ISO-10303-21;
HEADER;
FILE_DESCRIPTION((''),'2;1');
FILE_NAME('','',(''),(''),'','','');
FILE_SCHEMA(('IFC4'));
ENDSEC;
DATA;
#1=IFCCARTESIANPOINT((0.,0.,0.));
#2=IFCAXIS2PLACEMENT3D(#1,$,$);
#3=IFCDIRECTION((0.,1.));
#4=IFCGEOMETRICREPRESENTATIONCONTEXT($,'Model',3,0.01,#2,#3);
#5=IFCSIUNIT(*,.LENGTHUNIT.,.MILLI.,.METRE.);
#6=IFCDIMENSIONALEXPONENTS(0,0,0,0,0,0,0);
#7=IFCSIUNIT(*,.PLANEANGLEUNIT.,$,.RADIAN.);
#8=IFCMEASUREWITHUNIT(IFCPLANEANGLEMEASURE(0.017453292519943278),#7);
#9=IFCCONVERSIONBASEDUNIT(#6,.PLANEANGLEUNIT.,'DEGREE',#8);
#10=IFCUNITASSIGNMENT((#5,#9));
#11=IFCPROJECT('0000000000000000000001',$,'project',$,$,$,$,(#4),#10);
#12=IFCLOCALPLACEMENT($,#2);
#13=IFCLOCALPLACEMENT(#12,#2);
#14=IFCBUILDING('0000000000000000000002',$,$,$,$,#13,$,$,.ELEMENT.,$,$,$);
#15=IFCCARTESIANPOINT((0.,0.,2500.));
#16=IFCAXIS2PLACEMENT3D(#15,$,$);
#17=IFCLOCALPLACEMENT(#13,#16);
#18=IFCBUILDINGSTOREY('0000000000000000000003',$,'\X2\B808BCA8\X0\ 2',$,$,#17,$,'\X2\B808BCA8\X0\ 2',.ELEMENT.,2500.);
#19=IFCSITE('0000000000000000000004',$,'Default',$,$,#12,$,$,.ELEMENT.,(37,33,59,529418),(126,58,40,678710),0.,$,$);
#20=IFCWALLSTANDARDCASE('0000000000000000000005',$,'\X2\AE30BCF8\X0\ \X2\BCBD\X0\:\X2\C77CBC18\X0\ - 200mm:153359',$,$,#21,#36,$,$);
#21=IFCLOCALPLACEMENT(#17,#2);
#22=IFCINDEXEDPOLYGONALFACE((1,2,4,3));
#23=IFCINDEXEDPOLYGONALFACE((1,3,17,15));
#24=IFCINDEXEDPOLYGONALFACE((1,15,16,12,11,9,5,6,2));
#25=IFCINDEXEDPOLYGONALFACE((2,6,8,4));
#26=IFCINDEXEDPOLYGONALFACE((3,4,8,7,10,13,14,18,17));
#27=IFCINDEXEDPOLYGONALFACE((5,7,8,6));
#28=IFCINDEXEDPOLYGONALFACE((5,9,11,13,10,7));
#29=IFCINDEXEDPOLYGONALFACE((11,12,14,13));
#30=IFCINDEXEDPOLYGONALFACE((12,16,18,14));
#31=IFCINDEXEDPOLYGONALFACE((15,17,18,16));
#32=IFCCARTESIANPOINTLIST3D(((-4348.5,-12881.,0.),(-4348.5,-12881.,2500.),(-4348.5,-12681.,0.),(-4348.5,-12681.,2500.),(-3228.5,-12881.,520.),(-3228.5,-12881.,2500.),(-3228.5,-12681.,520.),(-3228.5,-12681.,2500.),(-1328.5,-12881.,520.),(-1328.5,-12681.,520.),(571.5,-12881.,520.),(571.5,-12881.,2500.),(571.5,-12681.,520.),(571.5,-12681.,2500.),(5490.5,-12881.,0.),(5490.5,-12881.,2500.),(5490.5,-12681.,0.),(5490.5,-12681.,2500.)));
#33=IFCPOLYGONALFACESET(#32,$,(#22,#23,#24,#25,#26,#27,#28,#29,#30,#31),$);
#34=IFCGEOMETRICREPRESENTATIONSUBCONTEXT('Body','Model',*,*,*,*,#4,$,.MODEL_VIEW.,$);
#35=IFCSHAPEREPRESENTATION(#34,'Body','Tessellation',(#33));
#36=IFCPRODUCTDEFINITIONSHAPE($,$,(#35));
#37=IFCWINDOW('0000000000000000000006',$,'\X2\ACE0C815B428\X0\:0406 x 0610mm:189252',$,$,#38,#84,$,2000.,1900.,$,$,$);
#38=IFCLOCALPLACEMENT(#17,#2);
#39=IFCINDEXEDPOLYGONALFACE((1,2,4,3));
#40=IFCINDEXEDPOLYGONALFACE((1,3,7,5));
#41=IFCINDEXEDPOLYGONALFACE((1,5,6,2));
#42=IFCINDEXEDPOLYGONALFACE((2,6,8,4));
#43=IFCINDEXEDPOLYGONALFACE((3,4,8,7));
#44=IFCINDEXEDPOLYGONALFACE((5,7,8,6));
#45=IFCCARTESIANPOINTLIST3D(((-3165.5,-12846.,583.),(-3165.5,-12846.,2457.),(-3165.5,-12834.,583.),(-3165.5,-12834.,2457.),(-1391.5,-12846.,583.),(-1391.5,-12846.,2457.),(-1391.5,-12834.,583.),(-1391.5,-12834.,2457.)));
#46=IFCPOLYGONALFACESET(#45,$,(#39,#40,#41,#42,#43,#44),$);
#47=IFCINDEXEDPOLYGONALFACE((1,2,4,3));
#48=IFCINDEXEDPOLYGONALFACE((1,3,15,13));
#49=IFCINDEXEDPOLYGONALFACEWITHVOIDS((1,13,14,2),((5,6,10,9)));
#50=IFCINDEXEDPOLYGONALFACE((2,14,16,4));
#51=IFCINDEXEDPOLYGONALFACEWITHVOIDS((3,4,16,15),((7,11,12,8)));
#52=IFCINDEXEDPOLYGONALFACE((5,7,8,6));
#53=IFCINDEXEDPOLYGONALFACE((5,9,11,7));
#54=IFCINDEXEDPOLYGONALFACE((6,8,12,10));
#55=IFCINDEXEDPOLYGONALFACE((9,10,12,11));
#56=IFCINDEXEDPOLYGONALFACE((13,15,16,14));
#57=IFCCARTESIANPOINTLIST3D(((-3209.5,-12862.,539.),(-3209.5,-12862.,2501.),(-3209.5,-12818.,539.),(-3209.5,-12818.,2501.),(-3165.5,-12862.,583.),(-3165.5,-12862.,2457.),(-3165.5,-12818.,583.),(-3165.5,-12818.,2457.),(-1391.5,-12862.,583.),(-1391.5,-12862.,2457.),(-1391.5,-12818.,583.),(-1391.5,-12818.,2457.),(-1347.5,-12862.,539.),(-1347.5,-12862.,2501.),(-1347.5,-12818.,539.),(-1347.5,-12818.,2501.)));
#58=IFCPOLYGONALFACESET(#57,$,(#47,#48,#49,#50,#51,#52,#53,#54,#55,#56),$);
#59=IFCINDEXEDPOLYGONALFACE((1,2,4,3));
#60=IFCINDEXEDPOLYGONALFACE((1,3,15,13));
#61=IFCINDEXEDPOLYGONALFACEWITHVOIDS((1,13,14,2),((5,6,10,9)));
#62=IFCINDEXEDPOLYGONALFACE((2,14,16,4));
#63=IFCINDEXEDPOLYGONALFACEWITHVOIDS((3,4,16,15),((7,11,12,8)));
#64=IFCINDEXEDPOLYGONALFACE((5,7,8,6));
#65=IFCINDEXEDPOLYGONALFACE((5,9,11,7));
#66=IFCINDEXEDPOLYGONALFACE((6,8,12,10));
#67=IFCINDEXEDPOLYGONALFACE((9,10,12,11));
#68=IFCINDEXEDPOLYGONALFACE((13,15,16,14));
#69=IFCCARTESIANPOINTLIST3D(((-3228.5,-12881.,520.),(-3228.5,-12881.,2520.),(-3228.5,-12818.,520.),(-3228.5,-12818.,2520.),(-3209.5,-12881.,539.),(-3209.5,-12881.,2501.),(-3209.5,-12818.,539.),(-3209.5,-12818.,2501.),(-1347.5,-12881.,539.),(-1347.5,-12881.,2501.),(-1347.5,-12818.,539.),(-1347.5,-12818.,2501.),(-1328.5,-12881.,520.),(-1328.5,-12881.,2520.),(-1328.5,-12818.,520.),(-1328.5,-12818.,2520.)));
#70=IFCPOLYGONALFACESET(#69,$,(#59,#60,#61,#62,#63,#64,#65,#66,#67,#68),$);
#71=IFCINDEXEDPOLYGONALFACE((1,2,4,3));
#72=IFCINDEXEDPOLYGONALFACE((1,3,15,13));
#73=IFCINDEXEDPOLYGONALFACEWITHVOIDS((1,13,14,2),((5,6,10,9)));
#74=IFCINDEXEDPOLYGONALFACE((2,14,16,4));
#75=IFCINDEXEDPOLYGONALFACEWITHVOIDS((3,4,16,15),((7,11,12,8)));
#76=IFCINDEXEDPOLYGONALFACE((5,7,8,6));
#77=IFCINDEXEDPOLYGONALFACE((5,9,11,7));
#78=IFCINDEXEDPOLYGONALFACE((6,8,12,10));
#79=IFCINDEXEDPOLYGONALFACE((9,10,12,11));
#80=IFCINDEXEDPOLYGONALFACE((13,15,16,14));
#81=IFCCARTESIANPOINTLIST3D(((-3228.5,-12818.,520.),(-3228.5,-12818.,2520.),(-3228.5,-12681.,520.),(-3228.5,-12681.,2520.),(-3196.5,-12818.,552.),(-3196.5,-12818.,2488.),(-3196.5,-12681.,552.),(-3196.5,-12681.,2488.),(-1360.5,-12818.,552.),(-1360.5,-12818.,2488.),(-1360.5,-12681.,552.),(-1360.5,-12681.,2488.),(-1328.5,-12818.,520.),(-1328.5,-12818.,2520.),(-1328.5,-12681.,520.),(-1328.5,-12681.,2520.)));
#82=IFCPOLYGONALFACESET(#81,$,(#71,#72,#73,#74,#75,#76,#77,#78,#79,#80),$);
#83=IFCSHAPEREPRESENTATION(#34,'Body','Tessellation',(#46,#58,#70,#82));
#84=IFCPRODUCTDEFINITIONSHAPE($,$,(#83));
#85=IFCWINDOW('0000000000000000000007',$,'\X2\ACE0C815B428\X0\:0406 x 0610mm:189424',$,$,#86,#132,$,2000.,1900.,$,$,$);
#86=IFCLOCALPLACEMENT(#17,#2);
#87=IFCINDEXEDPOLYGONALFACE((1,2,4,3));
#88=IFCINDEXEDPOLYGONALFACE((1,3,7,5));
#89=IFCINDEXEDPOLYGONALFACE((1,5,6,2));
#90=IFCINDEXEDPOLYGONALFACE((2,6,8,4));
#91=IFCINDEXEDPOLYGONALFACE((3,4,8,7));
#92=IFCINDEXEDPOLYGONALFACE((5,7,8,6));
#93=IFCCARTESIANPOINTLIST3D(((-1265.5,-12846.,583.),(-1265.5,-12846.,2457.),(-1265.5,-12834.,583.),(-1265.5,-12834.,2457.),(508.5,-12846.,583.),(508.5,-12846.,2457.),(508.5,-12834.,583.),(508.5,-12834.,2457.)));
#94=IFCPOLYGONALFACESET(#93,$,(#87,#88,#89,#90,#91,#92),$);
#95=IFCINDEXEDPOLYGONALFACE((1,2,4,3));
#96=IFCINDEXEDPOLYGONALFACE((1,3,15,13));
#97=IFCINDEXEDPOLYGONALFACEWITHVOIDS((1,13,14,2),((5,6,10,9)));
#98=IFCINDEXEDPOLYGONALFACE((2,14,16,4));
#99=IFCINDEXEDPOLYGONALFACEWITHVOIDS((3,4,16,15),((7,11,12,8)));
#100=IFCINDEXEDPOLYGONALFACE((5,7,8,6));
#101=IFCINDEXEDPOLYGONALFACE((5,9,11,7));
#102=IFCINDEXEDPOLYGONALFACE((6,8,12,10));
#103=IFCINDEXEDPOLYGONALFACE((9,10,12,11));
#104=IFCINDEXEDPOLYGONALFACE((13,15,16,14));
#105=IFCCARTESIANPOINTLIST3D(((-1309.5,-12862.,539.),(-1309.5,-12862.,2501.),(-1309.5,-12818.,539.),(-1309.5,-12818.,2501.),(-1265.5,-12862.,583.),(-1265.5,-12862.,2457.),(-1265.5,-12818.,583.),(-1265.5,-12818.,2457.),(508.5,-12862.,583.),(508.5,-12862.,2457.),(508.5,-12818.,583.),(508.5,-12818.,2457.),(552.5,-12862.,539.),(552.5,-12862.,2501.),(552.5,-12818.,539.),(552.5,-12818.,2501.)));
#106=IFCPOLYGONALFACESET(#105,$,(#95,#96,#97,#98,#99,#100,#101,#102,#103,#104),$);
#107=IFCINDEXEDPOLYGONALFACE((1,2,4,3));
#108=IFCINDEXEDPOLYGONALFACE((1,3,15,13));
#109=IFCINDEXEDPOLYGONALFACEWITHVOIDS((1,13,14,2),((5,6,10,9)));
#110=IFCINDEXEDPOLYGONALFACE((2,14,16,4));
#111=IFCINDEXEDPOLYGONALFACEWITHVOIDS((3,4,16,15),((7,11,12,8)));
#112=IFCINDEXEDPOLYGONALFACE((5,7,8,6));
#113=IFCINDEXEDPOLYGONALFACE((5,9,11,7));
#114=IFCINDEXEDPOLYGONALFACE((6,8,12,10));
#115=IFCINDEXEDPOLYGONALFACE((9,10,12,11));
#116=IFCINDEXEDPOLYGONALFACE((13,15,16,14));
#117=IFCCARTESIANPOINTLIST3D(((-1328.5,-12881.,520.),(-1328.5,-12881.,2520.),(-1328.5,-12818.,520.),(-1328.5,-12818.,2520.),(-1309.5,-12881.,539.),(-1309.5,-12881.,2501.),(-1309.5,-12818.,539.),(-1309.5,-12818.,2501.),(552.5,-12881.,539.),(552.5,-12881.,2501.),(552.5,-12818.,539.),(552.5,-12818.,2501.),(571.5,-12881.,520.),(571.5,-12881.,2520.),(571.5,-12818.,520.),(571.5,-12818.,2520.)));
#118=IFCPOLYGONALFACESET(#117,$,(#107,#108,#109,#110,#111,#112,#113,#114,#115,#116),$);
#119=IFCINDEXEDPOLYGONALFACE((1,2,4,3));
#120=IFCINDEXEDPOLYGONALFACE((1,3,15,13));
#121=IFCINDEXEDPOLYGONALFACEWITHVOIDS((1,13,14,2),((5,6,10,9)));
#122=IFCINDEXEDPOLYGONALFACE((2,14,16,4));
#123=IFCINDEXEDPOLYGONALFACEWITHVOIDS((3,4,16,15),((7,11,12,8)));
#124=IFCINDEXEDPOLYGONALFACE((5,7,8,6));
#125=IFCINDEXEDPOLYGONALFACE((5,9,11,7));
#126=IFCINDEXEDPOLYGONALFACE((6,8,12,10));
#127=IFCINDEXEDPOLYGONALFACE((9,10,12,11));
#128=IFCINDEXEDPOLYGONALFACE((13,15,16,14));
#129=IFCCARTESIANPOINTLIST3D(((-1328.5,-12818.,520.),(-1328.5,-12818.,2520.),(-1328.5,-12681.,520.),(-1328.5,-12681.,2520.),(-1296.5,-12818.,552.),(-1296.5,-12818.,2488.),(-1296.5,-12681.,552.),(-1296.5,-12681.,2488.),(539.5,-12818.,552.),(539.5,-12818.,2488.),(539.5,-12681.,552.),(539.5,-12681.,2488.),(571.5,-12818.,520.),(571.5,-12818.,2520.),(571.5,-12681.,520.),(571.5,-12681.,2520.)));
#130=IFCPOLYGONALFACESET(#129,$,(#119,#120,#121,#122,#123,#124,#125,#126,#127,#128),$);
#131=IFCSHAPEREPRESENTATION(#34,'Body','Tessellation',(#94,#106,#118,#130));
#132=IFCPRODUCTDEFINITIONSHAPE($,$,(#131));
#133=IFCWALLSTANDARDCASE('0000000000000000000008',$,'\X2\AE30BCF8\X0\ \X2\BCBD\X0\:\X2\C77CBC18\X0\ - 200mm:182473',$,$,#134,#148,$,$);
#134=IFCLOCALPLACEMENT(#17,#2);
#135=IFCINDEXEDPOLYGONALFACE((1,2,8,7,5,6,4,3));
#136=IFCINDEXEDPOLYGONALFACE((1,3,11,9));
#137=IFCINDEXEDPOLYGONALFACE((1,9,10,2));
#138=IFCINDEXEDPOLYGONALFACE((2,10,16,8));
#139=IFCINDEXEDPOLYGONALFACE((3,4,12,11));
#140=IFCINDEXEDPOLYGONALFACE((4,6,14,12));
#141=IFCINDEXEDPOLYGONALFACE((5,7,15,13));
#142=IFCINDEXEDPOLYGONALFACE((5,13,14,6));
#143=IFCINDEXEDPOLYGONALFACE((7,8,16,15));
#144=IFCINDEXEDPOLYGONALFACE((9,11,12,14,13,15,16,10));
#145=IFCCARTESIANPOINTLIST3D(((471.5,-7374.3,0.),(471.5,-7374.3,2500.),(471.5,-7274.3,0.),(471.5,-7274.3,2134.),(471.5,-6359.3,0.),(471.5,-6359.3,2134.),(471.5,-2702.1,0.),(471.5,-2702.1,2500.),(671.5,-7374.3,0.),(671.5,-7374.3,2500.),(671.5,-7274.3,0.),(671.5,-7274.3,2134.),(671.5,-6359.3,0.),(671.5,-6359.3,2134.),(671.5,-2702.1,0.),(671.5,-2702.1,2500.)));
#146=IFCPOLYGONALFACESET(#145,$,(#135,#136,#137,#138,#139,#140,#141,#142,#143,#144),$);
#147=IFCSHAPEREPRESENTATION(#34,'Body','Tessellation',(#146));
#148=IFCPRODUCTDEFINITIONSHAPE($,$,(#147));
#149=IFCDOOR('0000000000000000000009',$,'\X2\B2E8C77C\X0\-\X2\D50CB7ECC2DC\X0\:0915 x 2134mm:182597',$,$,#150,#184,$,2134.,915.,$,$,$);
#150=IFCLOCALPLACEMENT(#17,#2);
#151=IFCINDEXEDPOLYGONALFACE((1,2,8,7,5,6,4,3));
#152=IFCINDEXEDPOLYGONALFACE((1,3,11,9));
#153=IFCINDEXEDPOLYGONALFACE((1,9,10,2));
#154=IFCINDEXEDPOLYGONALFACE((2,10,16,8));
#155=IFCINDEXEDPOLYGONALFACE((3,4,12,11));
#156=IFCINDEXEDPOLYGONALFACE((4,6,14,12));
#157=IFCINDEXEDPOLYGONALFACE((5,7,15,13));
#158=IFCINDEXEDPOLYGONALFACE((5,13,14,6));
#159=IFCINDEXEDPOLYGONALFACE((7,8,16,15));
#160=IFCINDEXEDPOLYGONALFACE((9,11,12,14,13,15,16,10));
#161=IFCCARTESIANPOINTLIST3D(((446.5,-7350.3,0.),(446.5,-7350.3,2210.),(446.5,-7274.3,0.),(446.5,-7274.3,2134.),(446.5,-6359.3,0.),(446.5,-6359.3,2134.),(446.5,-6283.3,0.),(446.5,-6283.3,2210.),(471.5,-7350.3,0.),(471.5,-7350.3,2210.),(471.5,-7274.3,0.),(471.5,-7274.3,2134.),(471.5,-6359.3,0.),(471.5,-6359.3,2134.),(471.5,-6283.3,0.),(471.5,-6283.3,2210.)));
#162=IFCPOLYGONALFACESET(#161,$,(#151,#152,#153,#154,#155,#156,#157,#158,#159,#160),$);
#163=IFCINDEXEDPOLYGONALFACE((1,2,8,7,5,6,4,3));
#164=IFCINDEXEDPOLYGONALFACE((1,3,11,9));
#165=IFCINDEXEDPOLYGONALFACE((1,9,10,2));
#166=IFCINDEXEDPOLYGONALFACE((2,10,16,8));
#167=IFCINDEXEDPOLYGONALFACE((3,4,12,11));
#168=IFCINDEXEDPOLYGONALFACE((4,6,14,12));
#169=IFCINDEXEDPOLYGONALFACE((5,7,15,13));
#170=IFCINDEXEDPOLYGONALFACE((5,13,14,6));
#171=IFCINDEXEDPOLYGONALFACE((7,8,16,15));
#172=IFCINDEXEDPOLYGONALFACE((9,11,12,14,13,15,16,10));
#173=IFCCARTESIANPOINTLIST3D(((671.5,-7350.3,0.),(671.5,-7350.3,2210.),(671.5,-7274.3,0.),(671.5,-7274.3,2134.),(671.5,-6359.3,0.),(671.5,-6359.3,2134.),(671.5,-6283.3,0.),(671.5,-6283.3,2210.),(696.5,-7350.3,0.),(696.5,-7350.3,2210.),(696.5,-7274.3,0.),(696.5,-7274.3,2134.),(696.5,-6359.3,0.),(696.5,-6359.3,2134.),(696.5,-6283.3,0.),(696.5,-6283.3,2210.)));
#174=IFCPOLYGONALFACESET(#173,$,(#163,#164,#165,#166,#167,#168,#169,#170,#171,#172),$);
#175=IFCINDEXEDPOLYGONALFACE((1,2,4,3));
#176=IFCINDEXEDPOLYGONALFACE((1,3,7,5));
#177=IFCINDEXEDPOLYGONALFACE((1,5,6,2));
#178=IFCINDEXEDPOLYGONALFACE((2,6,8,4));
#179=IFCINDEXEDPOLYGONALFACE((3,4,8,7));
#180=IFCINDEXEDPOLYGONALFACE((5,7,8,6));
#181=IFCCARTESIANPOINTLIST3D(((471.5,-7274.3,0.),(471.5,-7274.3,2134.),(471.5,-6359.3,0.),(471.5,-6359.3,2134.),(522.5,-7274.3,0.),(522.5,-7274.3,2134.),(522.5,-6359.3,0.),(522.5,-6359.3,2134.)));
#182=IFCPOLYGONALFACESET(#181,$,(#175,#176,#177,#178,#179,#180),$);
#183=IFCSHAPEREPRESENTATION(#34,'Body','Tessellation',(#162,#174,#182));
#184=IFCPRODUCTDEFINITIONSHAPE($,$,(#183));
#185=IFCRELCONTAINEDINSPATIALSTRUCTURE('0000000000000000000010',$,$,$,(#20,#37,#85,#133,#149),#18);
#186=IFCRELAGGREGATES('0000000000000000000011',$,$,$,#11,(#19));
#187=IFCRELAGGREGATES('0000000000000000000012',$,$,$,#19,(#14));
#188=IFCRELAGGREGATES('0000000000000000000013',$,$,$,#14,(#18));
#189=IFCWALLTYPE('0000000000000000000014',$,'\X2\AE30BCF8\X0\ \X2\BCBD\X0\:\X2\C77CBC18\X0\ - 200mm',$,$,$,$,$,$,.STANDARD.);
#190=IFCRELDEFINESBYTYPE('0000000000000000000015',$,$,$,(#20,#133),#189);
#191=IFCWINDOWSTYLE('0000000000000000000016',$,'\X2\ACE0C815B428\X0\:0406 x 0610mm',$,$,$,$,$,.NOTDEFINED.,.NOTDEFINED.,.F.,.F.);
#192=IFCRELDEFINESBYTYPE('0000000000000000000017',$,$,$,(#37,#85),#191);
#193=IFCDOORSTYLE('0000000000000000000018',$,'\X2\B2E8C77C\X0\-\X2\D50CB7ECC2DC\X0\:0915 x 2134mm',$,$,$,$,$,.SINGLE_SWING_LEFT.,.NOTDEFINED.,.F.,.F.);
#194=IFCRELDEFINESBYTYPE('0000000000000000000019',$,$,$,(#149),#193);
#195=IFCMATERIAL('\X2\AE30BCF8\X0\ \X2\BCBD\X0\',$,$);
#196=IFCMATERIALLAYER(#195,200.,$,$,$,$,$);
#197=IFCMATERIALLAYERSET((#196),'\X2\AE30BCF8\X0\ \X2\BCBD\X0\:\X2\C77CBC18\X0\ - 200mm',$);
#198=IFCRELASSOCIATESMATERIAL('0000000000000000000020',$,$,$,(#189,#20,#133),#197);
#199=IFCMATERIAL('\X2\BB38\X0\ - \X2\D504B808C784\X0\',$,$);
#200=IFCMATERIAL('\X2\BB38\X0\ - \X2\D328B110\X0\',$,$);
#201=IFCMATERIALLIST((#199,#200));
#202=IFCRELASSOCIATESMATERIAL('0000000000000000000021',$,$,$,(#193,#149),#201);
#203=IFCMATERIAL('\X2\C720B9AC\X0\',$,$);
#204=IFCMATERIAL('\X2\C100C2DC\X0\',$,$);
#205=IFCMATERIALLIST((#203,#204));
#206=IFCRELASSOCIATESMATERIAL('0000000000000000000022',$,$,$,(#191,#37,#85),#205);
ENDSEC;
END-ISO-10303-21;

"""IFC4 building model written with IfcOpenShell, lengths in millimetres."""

from ifc_helpers import new_model, entity, si_unit, converted_unit, direction, frame, frame_2d, origin, place, context, subcontext, project, spatial, polyline, rectangle, outline, extrude, source, transform, mapped, material, material_list, layer, layer_set, layer_usage, type_object, type_shapes, element, fill, save


model = new_model("IFC4")

# Units and contexts
model_context = context("Model", 3, precision=0.01, world=origin(), true_north=direction((0.0, 1.0)))
body_context = subcontext(model_context, "Body", "Model", "MODEL_VIEW")
ifc_project = project(units=[si_unit("LENGTHUNIT", "METRE", prefix="MILLI"), converted_unit("PLANEANGLEUNIT", "DEGREE", entity("IfcPlaneAngleMeasure", 0.017453292519943278), si_unit("PLANEANGLEUNIT", "RADIAN"), dimensions=[0, 0, 0, 0, 0, 0, 0])], contexts=[model_context])

# Site, building, storey
site_placement = place(None, origin())
site = spatial("IfcSite", under=ifc_project, at=site_placement, Name="Default", CompositionType="ELEMENT", RefLatitude=(37, 33, 59, 529418), RefLongitude=(126, 58, 40, 678710), RefElevation=0.0)
building_placement = place(site_placement, origin())
building = spatial("IfcBuilding", under=site, at=building_placement, CompositionType="ELEMENT")
storey_placement = place(building_placement, frame((0.0, 0.0, 2500.0)))
storey = spatial("IfcBuildingStorey", under=building, at=storey_placement, Name="레벨 2", LongName="레벨 2", CompositionType="ELEMENT", Elevation=2500.0)

# Shared definitions
ifc_material_1 = material(Name="기본 벽")
ifc_layer_1 = layer(ifc_material_1, 200.0)
ifc_layer_set_1 = layer_set([ifc_layer_1], Name="기본 벽:일반 - 200mm")
wall_type = type_object("IfcWallType", Name="기본 벽:일반 - 200mm", PredefinedType="STANDARD", material=ifc_layer_set_1)
ifc_material_2 = material(Name="문 - 프레임")
ifc_material_3 = material(Name="문 - 패널")
ifc_material_list_1 = material_list([ifc_material_2, ifc_material_3])
door_style = type_object("IfcDoorStyle", Name="단일-플러시:0915 x 2134mm", ConstructionType="NOTDEFINED", OperationType="SINGLE_SWING_LEFT", ParameterTakesPrecedence=False, Sizeable=False, material=ifc_material_list_1)
shared_shape_1 = source(origin(), body_context, "Body", "SweptSolid", [
    extrude(outline(polyline([(-533.5, -1124.0), (533.5, -1124.0), (533.5, 1086.0), (457.5, 1086.0), (457.5, -1048.0), (-457.5, -1048.0), (-457.5, 1086.0), (-533.5, 1086.0), (-533.5, -1124.0)])), frame((457.5, 225.0, 1086.0), z_axis=(0.0, -1.0, 0.0), x_axis=(-1.0, 0.0, 0.0)), (0.0, 0.0, 1.0), 25.0),
    extrude(outline(polyline([(-1124.0, -533.5), (1086.0, -533.5), (1086.0, -457.5), (-1048.0, -457.5), (-1048.0, 457.5), (1086.0, 457.5), (1086.0, 533.5), (-1124.0, 533.5), (-1124.0, -533.5)])), frame((457.5, 0.0, 1086.0), z_axis=(0.0, -1.0, 0.0), x_axis=(0.0, 0.0, -1.0)), (0.0, 0.0, 1.0), 25.0),
    extrude(rectangle(XDim=915.0, YDim=51.0, at=frame_2d((0.0, 0.0), x_axis=(1.0, 0.0))), frame((457.5, 174.5, 0.0)), (0.0, 0.0, 1.0), 2134.0),
])
type_shapes(door_style, [shared_shape_1])

# Wall, openings, windows
ifc_layer_usage_1 = layer_usage(ifc_layer_set_1, "AXIS2", "NEGATIVE", 100.0)
wall_1_placement = place(storey_placement, frame((5490.5, -12781.0, 0.0), z_axis=(0.0, 0.0, 1.0), x_axis=(-1.0, 0.0, 0.0)))
wall_1 = element("IfcWallStandardCase", 1, at=wall_1_placement, inside=storey, type_object=wall_type, material=ifc_layer_usage_1, Name="기본 벽:일반 - 200mm:153359", context=body_context, shape_type="SweptSolid", body=[
    extrude(rectangle(XDim=9839.0, YDim=200.0, at=frame_2d((4919.5, 0.0), x_axis=(-1.0, 0.0))), origin(), (0.0, 0.0, 1.0), 2500.0),
])
opening_1_placement = place(wall_1_placement, frame((6819.0, -100.0, 520.0)))
opening_1 = element("IfcOpeningElement", 2, at=opening_1_placement, cuts=wall_1, ObjectType="Opening", context=body_context, shape_type="SweptSolid", body=[
    extrude(rectangle(XDim=2000.0, YDim=1900.0, at=frame_2d((1000.0, 950.0), x_axis=(1.0, 0.0))), frame((0.0, 0.0, 0.0), z_axis=(0.0, 1.0, 0.0), x_axis=(0.0, 0.0, 1.0)), (0.0, 0.0, 1.0), 200.0),
])
opening_2_placement = place(wall_1_placement, frame((4919.0, -100.0, 520.0)))
opening_2 = element("IfcOpeningElement", 3, at=opening_2_placement, cuts=wall_1, ObjectType="Opening", context=body_context, shape_type="SweptSolid", body=[
    extrude(rectangle(XDim=2000.0, YDim=1900.0, at=frame_2d((1000.0, 950.0), x_axis=(1.0, 0.0))), frame((0.0, 0.0, 0.0), z_axis=(0.0, 1.0, 0.0), x_axis=(0.0, 0.0, 1.0)), (0.0, 0.0, 1.0), 200.0),
])
ifc_material_4 = material(Name="유리")
ifc_material_5 = material(Name="섀시")
ifc_material_list_2 = material_list([ifc_material_4, ifc_material_5])
window_style = type_object("IfcWindowStyle", Name="고정됨:0406 x 0610mm", ConstructionType="NOTDEFINED", OperationType="NOTDEFINED", ParameterTakesPrecedence=False, Sizeable=False, material=ifc_material_list_2)
shared_shape_2 = source(origin(), body_context, "Body", "SweptSolid", [
    extrude(rectangle(XDim=12.0, YDim=1774.0, at=frame_2d((0.0, 0.0), x_axis=(1.0, 0.0))), frame((950.0, 159.0, 63.0), z_axis=(0.0, 0.0, 1.0), x_axis=(0.0, -1.0, 0.0)), (0.0, 0.0, 1.0), 1874.0),
    extrude(outline(polyline([(-931.0, -981.0), (931.0, -981.0), (931.0, 981.0), (-931.0, 981.0), (-931.0, -981.0)]), holes=[polyline([(-887.0, -937.0), (-887.0, 937.0), (887.0, 937.0), (887.0, -937.0), (-887.0, -937.0)])]), frame((950.0, 137.0, 1000.0), z_axis=(0.0, 1.0, 0.0), x_axis=(1.0, 0.0, 0.0)), (0.0, 0.0, 1.0), 44.0),
    extrude(outline(polyline([(-950.0, -1000.0), (950.0, -1000.0), (950.0, 1000.0), (-950.0, 1000.0), (-950.0, -1000.0)]), holes=[polyline([(-931.0, -981.0), (-931.0, 981.0), (931.0, 981.0), (931.0, -981.0), (-931.0, -981.0)])]), frame((950.0, 137.0, 1000.0), z_axis=(0.0, 1.0, 0.0), x_axis=(1.0, 0.0, 0.0)), (0.0, 0.0, 1.0), 63.0),
    extrude(outline(polyline([(-950.0, -1000.0), (950.0, -1000.0), (950.0, 1000.0), (-950.0, 1000.0), (-950.0, -1000.0)]), holes=[polyline([(-918.0, -968.0), (-918.0, 968.0), (918.0, 968.0), (918.0, -968.0), (-918.0, -968.0)])]), frame((950.0, 0.0, 1000.0), z_axis=(0.0, 1.0, 0.0), x_axis=(1.0, 0.0, 0.0)), (0.0, 0.0, 1.0), 137.0),
])
type_shapes(window_style, [shared_shape_2])
window_1_placement = place(opening_1_placement, origin())
window_1 = element("IfcWindow", 4, at=window_1_placement, inside=storey, type_object=window_style, material=ifc_material_list_2, Name="고정됨:0406 x 0610mm:189252", OverallHeight=2000.0, OverallWidth=1900.0, context=body_context, shape_type="MappedRepresentation", body=[
    mapped(shared_shape_2, transform((0.0, 0.0, 0.0), scale=1.0)),
])
fill(opening_1, window_1)
window_2_placement = place(opening_2_placement, origin())
window_2 = element("IfcWindow", 5, at=window_2_placement, inside=storey, type_object=window_style, material=ifc_material_list_2, Name="고정됨:0406 x 0610mm:189424", OverallHeight=2000.0, OverallWidth=1900.0, context=body_context, shape_type="MappedRepresentation", body=[
    mapped(shared_shape_2, transform((0.0, 0.0, 0.0), scale=1.0)),
])
fill(opening_2, window_2)

# Wall, opening, door
ifc_layer_usage_2 = layer_usage(ifc_layer_set_1, "AXIS2", "NEGATIVE", 100.0)
wall_2_placement = place(storey_placement, frame((571.5, -7374.3, 0.0), z_axis=(0.0, 0.0, 1.0), x_axis=(0.0, 1.0, 0.0)))
wall_2 = element("IfcWallStandardCase", 6, at=wall_2_placement, inside=storey, type_object=wall_type, material=ifc_layer_usage_2, Name="기본 벽:일반 - 200mm:182473", context=body_context, shape_type="SweptSolid", body=[
    extrude(rectangle(XDim=4672.2, YDim=200.0, at=frame_2d((2336.1, 0.0), x_axis=(1.0, 0.0))), origin(), (0.0, 0.0, 1.0), 2500.0),
])
opening_3_placement = place(wall_2_placement, frame((100.0, -100.0, 0.0)))
opening_3 = element("IfcOpeningElement", 7, at=opening_3_placement, cuts=wall_2, ObjectType="Opening", context=body_context, shape_type="SweptSolid", body=[
    extrude(rectangle(XDim=915.0, YDim=2134.0, at=frame_2d((1067.0, 457.5), x_axis=(0.0, -1.0))), frame((0.0, 0.0, 0.0), z_axis=(0.0, 1.0, 0.0), x_axis=(0.0, 0.0, 1.0)), (0.0, 0.0, 1.0), 200.0),
])
door_1_placement = place(opening_3_placement, origin())
door_1 = element("IfcDoor", 8, at=door_1_placement, inside=storey, type_object=door_style, material=ifc_material_list_1, Name="단일-플러시:0915 x 2134mm:182597", OverallHeight=2134.0, OverallWidth=915.0, context=body_context, shape_type="MappedRepresentation", body=[
    mapped(shared_shape_1, transform((0.0, 0.0, 0.0), scale=1.0)),
])
fill(opening_3, door_1)

save(model, "model.ifc")
